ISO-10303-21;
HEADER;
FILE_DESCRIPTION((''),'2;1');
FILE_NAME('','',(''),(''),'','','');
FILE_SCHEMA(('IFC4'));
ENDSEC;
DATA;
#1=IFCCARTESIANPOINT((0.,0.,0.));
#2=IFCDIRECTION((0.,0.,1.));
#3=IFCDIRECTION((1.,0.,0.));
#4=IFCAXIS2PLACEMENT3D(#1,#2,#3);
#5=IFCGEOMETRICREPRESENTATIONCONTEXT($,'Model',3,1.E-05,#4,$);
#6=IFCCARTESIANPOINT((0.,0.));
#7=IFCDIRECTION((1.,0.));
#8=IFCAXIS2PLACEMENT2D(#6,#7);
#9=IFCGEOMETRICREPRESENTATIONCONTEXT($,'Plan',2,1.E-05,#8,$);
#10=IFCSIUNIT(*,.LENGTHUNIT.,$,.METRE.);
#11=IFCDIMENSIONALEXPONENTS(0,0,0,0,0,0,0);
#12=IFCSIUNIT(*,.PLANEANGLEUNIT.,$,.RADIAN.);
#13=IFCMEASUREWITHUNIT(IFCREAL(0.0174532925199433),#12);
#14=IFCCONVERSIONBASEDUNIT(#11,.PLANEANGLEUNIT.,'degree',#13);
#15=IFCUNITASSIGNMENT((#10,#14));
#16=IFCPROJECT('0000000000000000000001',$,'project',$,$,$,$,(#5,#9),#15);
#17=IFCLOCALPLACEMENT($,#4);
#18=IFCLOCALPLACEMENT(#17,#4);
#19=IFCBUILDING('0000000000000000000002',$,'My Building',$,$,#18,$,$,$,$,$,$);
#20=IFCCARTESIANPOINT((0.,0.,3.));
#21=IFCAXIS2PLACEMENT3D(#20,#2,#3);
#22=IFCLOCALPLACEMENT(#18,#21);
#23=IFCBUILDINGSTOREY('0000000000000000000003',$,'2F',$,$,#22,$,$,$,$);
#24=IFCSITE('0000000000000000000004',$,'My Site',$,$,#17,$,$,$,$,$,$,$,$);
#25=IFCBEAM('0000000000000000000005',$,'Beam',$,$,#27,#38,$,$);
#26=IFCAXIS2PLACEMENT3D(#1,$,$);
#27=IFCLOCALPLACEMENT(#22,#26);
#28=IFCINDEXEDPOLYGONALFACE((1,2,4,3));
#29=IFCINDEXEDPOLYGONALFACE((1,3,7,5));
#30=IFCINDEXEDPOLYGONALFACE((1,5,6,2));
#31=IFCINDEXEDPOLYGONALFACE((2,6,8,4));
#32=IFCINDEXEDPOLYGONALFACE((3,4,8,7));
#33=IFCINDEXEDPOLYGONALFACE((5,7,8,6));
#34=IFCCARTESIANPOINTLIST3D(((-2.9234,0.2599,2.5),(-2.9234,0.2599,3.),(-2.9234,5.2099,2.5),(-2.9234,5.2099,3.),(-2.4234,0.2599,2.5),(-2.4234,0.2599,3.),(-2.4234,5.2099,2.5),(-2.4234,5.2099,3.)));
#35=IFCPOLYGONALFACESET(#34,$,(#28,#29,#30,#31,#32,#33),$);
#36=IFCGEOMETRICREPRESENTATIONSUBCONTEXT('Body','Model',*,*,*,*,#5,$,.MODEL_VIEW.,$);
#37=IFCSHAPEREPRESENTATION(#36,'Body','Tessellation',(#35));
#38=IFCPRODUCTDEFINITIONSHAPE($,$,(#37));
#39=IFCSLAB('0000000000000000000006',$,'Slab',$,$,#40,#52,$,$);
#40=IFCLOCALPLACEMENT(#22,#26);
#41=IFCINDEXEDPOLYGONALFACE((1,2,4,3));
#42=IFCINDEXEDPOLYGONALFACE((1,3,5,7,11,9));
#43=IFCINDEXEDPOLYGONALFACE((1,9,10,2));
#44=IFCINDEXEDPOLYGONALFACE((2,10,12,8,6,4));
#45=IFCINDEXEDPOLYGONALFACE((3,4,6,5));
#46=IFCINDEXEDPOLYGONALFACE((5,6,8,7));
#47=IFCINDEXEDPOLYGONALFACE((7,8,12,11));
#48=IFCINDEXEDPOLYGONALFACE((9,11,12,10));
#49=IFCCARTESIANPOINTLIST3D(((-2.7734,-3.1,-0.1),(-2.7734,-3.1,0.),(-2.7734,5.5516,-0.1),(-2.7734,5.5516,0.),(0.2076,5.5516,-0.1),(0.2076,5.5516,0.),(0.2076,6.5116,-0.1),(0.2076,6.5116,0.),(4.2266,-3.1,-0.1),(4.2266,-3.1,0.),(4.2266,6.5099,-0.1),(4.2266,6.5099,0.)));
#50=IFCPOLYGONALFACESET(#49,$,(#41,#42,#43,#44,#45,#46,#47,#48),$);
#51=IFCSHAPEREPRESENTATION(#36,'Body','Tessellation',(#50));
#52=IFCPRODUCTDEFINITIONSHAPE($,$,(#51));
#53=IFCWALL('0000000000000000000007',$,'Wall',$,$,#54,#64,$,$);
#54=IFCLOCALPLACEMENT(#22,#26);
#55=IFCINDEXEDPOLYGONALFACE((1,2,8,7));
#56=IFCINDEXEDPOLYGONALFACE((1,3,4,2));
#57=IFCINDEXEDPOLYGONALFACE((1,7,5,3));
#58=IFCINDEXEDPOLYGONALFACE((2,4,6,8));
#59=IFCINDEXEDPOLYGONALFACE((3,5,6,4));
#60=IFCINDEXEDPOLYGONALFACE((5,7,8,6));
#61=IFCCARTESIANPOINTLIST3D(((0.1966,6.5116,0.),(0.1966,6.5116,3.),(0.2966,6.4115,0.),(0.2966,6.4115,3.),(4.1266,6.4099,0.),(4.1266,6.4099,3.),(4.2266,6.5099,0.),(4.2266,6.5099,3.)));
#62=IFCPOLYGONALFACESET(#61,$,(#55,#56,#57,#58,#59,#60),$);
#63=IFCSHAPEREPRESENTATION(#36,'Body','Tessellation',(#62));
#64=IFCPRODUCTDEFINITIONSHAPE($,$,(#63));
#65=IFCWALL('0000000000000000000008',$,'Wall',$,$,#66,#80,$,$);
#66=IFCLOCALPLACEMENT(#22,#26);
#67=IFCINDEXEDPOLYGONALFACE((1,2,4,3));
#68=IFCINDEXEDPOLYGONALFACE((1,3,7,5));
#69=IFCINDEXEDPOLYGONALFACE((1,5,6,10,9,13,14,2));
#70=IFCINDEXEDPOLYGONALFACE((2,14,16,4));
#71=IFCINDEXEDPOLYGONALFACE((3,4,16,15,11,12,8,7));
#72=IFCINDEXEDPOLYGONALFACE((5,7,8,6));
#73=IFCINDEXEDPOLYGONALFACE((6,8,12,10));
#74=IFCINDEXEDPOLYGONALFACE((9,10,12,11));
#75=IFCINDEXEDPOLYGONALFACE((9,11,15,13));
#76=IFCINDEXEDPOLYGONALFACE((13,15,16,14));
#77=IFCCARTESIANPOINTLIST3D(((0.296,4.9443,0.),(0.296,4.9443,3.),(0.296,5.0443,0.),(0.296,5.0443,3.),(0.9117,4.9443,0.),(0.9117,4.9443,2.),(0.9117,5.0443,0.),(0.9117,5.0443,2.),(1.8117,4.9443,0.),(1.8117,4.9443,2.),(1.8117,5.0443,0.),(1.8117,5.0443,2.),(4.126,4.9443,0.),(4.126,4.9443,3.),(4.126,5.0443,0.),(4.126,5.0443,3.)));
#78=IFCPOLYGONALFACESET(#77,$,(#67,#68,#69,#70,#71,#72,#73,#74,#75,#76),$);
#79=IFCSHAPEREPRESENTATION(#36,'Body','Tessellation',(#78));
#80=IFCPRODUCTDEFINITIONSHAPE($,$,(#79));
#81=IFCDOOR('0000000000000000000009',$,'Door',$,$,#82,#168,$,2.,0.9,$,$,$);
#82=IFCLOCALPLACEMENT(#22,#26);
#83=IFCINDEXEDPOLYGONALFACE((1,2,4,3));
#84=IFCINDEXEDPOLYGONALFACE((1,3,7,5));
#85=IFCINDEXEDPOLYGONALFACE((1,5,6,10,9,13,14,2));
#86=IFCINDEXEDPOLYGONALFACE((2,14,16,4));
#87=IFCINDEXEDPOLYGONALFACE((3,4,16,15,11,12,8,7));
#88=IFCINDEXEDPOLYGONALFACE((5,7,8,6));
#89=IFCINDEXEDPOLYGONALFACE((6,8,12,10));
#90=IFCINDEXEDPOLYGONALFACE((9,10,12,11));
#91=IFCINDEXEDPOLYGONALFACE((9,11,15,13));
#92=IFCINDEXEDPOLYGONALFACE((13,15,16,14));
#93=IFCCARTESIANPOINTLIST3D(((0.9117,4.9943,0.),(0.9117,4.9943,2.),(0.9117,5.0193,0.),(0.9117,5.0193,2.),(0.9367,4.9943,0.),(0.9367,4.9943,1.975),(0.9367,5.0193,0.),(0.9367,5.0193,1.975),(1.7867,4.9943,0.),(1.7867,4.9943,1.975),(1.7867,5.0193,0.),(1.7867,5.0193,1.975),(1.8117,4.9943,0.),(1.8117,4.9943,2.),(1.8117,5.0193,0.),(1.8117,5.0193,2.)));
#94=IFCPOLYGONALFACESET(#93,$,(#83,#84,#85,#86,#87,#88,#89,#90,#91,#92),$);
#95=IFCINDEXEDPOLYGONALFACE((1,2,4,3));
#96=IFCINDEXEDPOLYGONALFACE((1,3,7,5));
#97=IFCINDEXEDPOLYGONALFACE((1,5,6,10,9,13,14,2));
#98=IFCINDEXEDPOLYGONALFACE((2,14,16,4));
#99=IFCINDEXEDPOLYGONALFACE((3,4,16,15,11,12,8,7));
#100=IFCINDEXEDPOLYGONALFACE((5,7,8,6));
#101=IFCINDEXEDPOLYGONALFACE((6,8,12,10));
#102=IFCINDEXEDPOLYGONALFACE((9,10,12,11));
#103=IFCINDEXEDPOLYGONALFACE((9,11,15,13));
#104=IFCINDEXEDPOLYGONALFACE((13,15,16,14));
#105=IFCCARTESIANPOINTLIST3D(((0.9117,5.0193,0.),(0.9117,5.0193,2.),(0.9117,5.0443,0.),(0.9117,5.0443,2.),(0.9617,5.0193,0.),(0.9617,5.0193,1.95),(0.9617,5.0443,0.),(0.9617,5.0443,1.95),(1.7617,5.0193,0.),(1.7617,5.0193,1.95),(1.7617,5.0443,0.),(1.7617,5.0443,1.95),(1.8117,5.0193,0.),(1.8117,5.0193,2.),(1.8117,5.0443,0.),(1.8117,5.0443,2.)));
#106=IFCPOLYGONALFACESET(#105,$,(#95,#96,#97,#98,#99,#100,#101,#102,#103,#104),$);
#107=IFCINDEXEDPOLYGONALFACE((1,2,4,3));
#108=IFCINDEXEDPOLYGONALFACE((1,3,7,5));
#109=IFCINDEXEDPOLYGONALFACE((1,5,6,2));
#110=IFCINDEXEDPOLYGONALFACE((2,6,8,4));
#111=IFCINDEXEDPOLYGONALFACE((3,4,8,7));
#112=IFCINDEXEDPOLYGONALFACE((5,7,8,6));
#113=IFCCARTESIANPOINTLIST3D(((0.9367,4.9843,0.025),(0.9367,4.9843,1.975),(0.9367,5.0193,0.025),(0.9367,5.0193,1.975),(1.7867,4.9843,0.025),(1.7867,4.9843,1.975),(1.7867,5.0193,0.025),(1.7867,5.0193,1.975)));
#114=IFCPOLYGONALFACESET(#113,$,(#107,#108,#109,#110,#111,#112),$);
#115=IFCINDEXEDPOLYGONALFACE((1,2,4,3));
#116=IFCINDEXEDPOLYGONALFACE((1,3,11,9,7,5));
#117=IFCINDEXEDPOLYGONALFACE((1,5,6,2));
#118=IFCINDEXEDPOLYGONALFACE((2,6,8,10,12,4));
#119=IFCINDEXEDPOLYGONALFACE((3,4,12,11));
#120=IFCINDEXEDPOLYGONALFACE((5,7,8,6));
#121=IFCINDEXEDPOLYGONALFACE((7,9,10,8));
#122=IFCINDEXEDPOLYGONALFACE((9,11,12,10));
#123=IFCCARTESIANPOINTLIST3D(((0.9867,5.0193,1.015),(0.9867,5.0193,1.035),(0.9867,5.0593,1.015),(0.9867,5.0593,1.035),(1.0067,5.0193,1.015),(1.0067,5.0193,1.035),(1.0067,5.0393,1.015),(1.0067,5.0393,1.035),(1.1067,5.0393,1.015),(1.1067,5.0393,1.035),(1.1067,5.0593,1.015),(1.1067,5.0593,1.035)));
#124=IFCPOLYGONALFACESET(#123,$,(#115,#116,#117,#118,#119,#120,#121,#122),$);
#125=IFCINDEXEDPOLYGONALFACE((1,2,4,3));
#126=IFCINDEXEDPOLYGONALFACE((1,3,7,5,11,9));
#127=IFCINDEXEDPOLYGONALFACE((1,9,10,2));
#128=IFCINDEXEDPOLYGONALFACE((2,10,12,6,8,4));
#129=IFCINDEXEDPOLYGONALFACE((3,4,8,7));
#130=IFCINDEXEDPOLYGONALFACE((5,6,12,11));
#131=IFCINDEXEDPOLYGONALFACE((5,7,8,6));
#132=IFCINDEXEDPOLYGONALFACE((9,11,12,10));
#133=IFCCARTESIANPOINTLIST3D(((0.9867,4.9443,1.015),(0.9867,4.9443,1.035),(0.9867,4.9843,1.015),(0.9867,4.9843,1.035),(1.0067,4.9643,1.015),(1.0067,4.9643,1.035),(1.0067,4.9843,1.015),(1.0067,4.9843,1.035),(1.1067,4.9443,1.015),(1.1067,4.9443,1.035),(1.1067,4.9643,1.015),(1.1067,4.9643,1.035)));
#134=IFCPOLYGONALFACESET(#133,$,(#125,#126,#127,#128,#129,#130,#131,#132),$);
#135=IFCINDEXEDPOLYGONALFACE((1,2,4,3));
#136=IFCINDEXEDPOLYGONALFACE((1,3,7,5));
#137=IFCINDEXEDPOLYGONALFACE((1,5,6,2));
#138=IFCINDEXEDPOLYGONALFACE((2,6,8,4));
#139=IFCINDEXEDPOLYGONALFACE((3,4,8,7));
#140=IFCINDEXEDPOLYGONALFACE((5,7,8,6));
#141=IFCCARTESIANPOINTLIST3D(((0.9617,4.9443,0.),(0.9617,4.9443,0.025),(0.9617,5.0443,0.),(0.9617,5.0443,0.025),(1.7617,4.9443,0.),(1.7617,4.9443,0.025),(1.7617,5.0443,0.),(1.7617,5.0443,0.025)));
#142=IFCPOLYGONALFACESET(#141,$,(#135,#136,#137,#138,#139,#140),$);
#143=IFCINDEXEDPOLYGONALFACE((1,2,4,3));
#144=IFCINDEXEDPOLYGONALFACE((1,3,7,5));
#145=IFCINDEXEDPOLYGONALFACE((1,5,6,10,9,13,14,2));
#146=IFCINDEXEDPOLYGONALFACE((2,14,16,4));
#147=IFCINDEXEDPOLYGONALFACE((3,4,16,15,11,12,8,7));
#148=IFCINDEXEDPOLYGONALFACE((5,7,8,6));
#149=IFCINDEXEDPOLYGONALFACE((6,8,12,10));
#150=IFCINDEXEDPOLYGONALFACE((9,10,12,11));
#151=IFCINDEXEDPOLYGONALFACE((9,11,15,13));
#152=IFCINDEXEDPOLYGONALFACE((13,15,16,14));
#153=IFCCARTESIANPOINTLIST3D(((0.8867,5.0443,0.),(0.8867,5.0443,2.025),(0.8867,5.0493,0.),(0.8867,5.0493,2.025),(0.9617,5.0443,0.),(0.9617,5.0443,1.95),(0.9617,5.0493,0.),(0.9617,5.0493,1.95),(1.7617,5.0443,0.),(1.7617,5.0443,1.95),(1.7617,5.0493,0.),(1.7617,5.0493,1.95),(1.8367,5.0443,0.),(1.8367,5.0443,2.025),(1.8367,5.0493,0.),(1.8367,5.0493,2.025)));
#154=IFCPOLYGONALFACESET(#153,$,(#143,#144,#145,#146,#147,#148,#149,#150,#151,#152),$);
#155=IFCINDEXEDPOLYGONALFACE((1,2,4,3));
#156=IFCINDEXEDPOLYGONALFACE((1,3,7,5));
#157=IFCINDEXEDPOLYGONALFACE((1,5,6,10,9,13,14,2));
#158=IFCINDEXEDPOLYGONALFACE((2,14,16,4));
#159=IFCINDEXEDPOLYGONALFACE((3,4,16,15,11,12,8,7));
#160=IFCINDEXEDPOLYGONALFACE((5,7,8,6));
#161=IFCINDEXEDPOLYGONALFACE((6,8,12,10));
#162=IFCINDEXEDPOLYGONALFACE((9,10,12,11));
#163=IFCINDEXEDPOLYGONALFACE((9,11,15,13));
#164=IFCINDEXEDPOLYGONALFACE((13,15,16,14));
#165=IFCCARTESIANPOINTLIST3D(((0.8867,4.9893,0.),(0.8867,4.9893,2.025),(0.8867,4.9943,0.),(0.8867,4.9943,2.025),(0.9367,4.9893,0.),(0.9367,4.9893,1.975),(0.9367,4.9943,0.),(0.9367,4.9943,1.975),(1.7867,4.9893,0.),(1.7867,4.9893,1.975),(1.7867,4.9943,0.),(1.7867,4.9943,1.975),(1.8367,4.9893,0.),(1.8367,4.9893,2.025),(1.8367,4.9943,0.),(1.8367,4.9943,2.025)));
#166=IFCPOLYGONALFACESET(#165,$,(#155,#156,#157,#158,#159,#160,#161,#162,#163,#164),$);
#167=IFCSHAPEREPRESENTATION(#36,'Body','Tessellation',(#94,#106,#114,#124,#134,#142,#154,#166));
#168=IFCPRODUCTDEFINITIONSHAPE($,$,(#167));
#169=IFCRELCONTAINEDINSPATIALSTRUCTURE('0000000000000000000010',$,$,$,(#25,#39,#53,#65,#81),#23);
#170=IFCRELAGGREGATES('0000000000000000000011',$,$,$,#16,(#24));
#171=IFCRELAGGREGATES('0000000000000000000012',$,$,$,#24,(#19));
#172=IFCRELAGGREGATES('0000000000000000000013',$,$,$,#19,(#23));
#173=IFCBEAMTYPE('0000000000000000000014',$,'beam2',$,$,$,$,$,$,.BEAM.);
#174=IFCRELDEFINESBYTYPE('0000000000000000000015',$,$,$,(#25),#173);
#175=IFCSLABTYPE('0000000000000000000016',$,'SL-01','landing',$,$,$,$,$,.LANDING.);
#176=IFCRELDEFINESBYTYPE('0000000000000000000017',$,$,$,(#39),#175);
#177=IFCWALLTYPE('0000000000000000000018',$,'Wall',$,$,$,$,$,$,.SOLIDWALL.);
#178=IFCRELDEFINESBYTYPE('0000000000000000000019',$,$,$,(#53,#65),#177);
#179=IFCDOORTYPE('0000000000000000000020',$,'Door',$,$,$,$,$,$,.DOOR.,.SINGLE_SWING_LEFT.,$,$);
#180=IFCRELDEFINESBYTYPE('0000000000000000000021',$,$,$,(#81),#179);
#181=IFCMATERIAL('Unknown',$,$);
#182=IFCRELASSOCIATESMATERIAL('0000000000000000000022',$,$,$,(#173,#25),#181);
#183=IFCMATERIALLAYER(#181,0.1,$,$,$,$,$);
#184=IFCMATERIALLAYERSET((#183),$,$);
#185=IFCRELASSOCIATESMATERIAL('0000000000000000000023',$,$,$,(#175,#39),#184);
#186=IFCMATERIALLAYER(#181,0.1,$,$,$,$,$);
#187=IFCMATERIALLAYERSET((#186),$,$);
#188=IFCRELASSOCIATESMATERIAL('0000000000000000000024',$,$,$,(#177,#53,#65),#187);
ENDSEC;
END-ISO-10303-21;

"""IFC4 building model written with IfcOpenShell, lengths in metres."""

from ifc_helpers import new_model, entity, si_unit, converted_unit, frame, origin_with_axes, origin_2d_with_axis, place, context, subcontext, project, spatial, line, indexed_curve, rectangle, outline, extrude, shape, source, transform, mapped, material, layer, layer_set, layer_usage, material_profile, profile_set, profile_usage, type_object, type_shapes, element, fill, save


model = new_model("IFC4")

# Units and contexts
model_context = context("Model", 3, precision=1e-05, world=origin_with_axes())
plan_context = context("Plan", 2, precision=1e-05, world=origin_2d_with_axis())
body_context_1 = subcontext(model_context, "Body", "Model", "MODEL_VIEW")
body_context_2 = subcontext(plan_context, "Body", "Plan", "PLAN_VIEW")
ifc_project = project(units=[si_unit("LENGTHUNIT", "METRE"), converted_unit("PLANEANGLEUNIT", "degree", entity("IfcReal", 0.0174532925199433), si_unit("PLANEANGLEUNIT", "RADIAN"), dimensions=[0, 0, 0, 0, 0, 0, 0])], contexts=[model_context, plan_context])

# Site, building, storey
site_placement = place(None, origin_with_axes())
site = spatial("IfcSite", under=ifc_project, at=site_placement, Name="My Site")
building_placement = place(site_placement, origin_with_axes())
building = spatial("IfcBuilding", under=site, at=building_placement, Name="My Building")
storey_placement = place(building_placement, frame((0.0, 0.0, 3.0), z_axis=(0.0, 0.0, 1.0), x_axis=(1.0, 0.0, 0.0)))
storey = spatial("IfcBuildingStorey", under=building, at=storey_placement, Name="2F")

# Shared definitions
ifc_material = material(Name="Unknown")

# Beam
ifc_material_profile_1 = material_profile(ifc_material, rectangle(XDim=0.5, YDim=0.5))
ifc_profile_set_1 = profile_set([ifc_material_profile_1])
beam_type_1 = type_object("IfcBeamType", Name="beam2", PredefinedType="BEAM", material=ifc_profile_set_1)
ifc_profile_usage_1 = profile_usage(ifc_profile_set_1, cardinal=7)
beam_1_placement = place(storey_placement, frame((-2.4234, 5.2099, 3.0), z_axis=(0.0, -1.0, 0.0), x_axis=(1.0, 0.0, 0.0)))
element("IfcBeam", 1, at=beam_1_placement, inside=storey, type_object=beam_type_1, material=ifc_profile_usage_1, Name="Beam", context=body_context_1, shape_type="SweptSolid", body=[
    extrude(rectangle(XDim=0.5, YDim=0.5), frame((-0.25, -0.25, 0.0), z_axis=(0.0, 0.0, 1.0), x_axis=(1.0, 0.0, 0.0)), (0.0, 0.0, 1.0), 4.95),
])

# Slab
ifc_layer_1 = layer(ifc_material, 0.1)
ifc_layer_set_1 = layer_set([ifc_layer_1])
ifc_layer_usage_1 = layer_usage(ifc_layer_set_1, "AXIS3", "POSITIVE", -0.1)
slab_type = type_object("IfcSlabType", Name="SL-01", Description="landing", PredefinedType="LANDING", material=ifc_layer_set_1)
slab_placement = place(storey_placement, frame((4.2266, 6.5099, 0.0), z_axis=(0.0, 0.0, 1.0), x_axis=(1.0, 0.0, 0.0)))
element("IfcSlab", 2, at=slab_placement, inside=storey, type_object=slab_type, material=ifc_layer_usage_1, Name="Slab", context=body_context_1, shape_type="SweptSolid", body=[
    extrude(outline(indexed_curve([(0.0, 0.0), (0.0, -9.6099), (-7.0, -9.6099), (-7.0, -0.9583), (-4.019, -0.9583), (-4.019, 0.0017), (0.0, 0.0)])), frame((0.0, 0.0, -0.1), z_axis=(0.0, 0.0, 1.0), x_axis=(1.0, 0.0, 0.0)), (0.0, 0.0, 1.0), 0.1),
])

# Wall
ifc_layer_2 = layer(ifc_material, 0.1)
ifc_layer_set_2 = layer_set([ifc_layer_2])
ifc_layer_usage_2 = layer_usage(ifc_layer_set_2, "AXIS2", "POSITIVE", 0.0)
wall_type = type_object("IfcWallType", Name="Wall", PredefinedType="SOLIDWALL", material=ifc_layer_set_2)
wall_1_placement = place(storey_placement, frame((4.2266, 6.5099, 0.0), z_axis=(0.0, 0.0, 1.0), x_axis=(-1.0, 0.000415, 0.0)))
element("IfcWall", 3, at=wall_1_placement, inside=storey, type_object=wall_type, material=ifc_layer_usage_2, Name="Wall", context=body_context_1, shape_type="SweptSolid", body=[
    extrude(outline(indexed_curve([(0.0, 0.0), (0.1, 0.1), (3.93, 0.1), (4.03, 0.0)], segments=[line(1, 2, 3, 4, 1)])), origin_with_axes(), (0.0, 0.0, 1.0), 3.0),
])

# Wall, opening, door
ifc_layer_usage_3 = layer_usage(ifc_layer_set_2, "AXIS2", "POSITIVE", 0.0)
wall_2_placement = place(storey_placement, frame((4.126, 5.0443, 0.0), z_axis=(0.0, 0.0, 1.0), x_axis=(-1.0, -0.000001, 0.0)))
wall_2 = element("IfcWall", 4, at=wall_2_placement, inside=storey, type_object=wall_type, material=ifc_layer_usage_3, Name="Wall", context=body_context_1, shape_type="SweptSolid", body=[
    extrude(outline(indexed_curve([(0.0, 0.0), (0.0, 0.1), (3.83, 0.1), (3.83, 0.0)], segments=[line(1, 2, 3, 4, 1)])), origin_with_axes(), (0.0, 0.0, 1.0), 3.0),
])
shared_shape_1 = source(origin_with_axes(), body_context_1, "Body", "SweptSolid", [
    extrude(outline(indexed_curve([(0.0, 0.0), (0.9, 0.0), (0.9, 2.0), (0.0, 2.0)], segments=[line(1, 2, 3, 4, 1)])), frame((0.0, -0.6, 0.0), z_axis=(0.0, -1.0, 0.0), x_axis=(1.0, 0.0, 0.0)), (0.0, 0.0, -1.0), 1.2),
])
opening_1_placement = place(wall_2_placement, frame((2.3143, 0.0, 0.0), z_axis=(0.0, 0.0, 1.0), x_axis=(1.0, 0.0, 0.0)))
opening_1 = element("IfcOpeningElement", 5, at=opening_1_placement, cuts=wall_2, PredefinedType="OPENING", context=body_context_1, shape_type="MappedRepresentation", body=[
    mapped(shared_shape_1, transform((0.0, 0.0, 0.0), x_axis=(1.0, 0.0, 0.0), y_axis=(0.0, 1.0, 0.0), z_axis=(0.0, 0.0, 1.0), scale=1.0)),
])
door_type = type_object("IfcDoorType", Name="Door", OperationType="SINGLE_SWING_LEFT", PredefinedType="DOOR")
shared_shape_2 = source(origin_with_axes(), body_context_1, "Body", "SweptSolid", [
    extrude(outline(indexed_curve([(0.0, 0.0), (0.0, 2.0), (0.9, 2.0), (0.9, 0.0), (0.875, 0.0), (0.875, 1.975), (0.025, 1.975), (0.025, 0.0)], segments=[line(1, 2, 3, 4, 5, 6, 7, 8, 1)])), frame((0.0, 0.025, 0.0), z_axis=(0.0, -1.0, 0.0), x_axis=(1.0, 0.0, 0.0)), (0.0, 0.0, -1.0), 0.025),
    extrude(outline(indexed_curve([(0.0, 0.0), (0.0, 2.0), (0.9, 2.0), (0.9, 0.0), (0.85, 0.0), (0.85, 1.95), (0.05, 1.95), (0.05, 0.0)], segments=[line(1, 2, 3, 4, 5, 6, 7, 8, 1)])), frame((0.0, 0.0, 0.0), z_axis=(0.0, -1.0, 0.0), x_axis=(1.0, 0.0, 0.0)), (0.0, 0.0, -1.0), 0.025),
    extrude(outline(indexed_curve([(0.0, 0.0), (0.85, 0.0), (0.85, 0.035), (0.0, 0.035)], segments=[line(1, 2, 3, 4, 1)])), frame((0.025, 0.025, 0.025), z_axis=(0.0, 0.0, 1.0), x_axis=(1.0, 0.0, 0.0)), (0.0, 0.0, 1.0), 1.95),
    extrude(outline(indexed_curve([(0.0, 0.0), (0.0, -0.04), (-0.12, -0.04), (-0.12, -0.02), (-0.02, -0.02), (-0.02, 0.0)], segments=[line(1, 2, 3, 4, 5, 6, 1)])), frame((0.825, 0.025, 1.015), z_axis=(0.0, 0.0, 1.0), x_axis=(1.0, 0.0, 0.0)), (0.0, 0.0, 1.0), 0.02),
    extrude(outline(indexed_curve([(0.0, 0.0), (0.0, 0.04), (-0.12, 0.04), (-0.12, 0.02), (-0.02, 0.02), (-0.02, 0.0)], segments=[line(1, 2, 3, 4, 5, 6, 1)])), frame((0.825, 0.06, 1.015), z_axis=(0.0, 0.0, 1.0), x_axis=(1.0, 0.0, 0.0)), (0.0, 0.0, 1.0), 0.02),
    extrude(outline(indexed_curve([(0.0, 0.0), (0.8, 0.0), (0.8, 0.1), (0.0, 0.1)], segments=[line(1, 2, 3, 4, 1)])), frame((0.05, 0.0, 0.0), z_axis=(0.0, 0.0, 1.0), x_axis=(1.0, 0.0, 0.0)), (0.0, 0.0, 1.0), 0.025),
    extrude(outline(indexed_curve([(0.0, 0.0), (0.0, 2.025), (0.95, 2.025), (0.95, 0.0), (0.875, 0.0), (0.875, 1.95), (0.075, 1.95), (0.075, 0.0)], segments=[line(1, 2, 3, 4, 5, 6, 7, 8, 1)])), frame((-0.025, -0.005, 0.0), z_axis=(0.0, -1.0, 0.0), x_axis=(1.0, 0.0, 0.0)), (0.0, 0.0, -1.0), 0.005),
    extrude(outline(indexed_curve([(0.0, 0.0), (0.0, 2.025), (0.95, 2.025), (0.95, 0.0), (0.9, 0.0), (0.9, 1.975), (0.05, 1.975), (0.05, 0.0)], segments=[line(1, 2, 3, 4, 5, 6, 7, 8, 1)])), frame((-0.025, 0.05, 0.0), z_axis=(0.0, -1.0, 0.0), x_axis=(1.0, 0.0, 0.0)), (0.0, 0.0, -1.0), 0.005),
])
shared_shape_3 = source(origin_with_axes(), body_context_2, "Body", "Curve2D", [
    entity("IfcIndexedPolyCurve", entity("IfcCartesianPointList2D", [[0.0, 0.0], [0.0, 0.05], [0.025, 0.05], [0.025, 0.025], [0.05, 0.025], [0.05, 0.0]]), [entity("IfcLineIndex", [1, 2, 3, 4, 5, 6, 1])]),
    entity("IfcIndexedPolyCurve", entity("IfcCartesianPointList2D", [[0.9, 0.0], [0.9, 0.05], [0.875, 0.05], [0.875, 0.025], [0.85, 0.025], [0.85, 0.0]]), [entity("IfcLineIndex", [1, 2, 3, 4, 5, 6, 1])]),
    entity("IfcTrimmedCurve", entity("IfcEllipse", entity("IfcAxis2Placement2D", entity("IfcCartesianPoint", [0.06, 0.05]), entity("IfcDirection", [1.0, 0.0])), 0.815, 0.85), [entity("IfcCartesianPoint", [0.875, 0.05])], [entity("IfcCartesianPoint", [0.06, 0.9])], True, "CARTESIAN"),
    entity("IfcIndexedPolyCurve", entity("IfcCartesianPointList2D", [[0.025, 0.05], [0.06, 0.05], [0.06, 0.9], [0.025, 0.9]]), [entity("IfcLineIndex", [1, 2, 3, 4, 1])]),
])
type_shapes(door_type, [shared_shape_2, shared_shape_3])
door_1_placement = place(opening_1_placement, frame((0.0, 0.0, 0.0), z_axis=(0.0, 0.0, 1.0), x_axis=(1.0, 0.0, 0.0)))
door_1 = element("IfcDoor", 6, at=door_1_placement, inside=storey, type_object=door_type, Name="Door", OverallHeight=2.0, OverallWidth=0.9, shapes=[
    shape(body_context_1, "Body", "MappedRepresentation", [mapped(shared_shape_2, transform((0.0, 0.0, 0.0), x_axis=(1.0, 0.0, 0.0), y_axis=(0.0, 1.0, 0.0), z_axis=(0.0, 0.0, 1.0), scale=1.0))]),
    shape(body_context_2, "Body", "MappedRepresentation", [mapped(shared_shape_3, transform((0.0, 0.0, 0.0), x_axis=(1.0, 0.0, 0.0), y_axis=(0.0, 1.0, 0.0), z_axis=(0.0, 0.0, 1.0), scale=1.0))]),
])
fill(opening_1, door_1)

save(model, "model.ifc")
